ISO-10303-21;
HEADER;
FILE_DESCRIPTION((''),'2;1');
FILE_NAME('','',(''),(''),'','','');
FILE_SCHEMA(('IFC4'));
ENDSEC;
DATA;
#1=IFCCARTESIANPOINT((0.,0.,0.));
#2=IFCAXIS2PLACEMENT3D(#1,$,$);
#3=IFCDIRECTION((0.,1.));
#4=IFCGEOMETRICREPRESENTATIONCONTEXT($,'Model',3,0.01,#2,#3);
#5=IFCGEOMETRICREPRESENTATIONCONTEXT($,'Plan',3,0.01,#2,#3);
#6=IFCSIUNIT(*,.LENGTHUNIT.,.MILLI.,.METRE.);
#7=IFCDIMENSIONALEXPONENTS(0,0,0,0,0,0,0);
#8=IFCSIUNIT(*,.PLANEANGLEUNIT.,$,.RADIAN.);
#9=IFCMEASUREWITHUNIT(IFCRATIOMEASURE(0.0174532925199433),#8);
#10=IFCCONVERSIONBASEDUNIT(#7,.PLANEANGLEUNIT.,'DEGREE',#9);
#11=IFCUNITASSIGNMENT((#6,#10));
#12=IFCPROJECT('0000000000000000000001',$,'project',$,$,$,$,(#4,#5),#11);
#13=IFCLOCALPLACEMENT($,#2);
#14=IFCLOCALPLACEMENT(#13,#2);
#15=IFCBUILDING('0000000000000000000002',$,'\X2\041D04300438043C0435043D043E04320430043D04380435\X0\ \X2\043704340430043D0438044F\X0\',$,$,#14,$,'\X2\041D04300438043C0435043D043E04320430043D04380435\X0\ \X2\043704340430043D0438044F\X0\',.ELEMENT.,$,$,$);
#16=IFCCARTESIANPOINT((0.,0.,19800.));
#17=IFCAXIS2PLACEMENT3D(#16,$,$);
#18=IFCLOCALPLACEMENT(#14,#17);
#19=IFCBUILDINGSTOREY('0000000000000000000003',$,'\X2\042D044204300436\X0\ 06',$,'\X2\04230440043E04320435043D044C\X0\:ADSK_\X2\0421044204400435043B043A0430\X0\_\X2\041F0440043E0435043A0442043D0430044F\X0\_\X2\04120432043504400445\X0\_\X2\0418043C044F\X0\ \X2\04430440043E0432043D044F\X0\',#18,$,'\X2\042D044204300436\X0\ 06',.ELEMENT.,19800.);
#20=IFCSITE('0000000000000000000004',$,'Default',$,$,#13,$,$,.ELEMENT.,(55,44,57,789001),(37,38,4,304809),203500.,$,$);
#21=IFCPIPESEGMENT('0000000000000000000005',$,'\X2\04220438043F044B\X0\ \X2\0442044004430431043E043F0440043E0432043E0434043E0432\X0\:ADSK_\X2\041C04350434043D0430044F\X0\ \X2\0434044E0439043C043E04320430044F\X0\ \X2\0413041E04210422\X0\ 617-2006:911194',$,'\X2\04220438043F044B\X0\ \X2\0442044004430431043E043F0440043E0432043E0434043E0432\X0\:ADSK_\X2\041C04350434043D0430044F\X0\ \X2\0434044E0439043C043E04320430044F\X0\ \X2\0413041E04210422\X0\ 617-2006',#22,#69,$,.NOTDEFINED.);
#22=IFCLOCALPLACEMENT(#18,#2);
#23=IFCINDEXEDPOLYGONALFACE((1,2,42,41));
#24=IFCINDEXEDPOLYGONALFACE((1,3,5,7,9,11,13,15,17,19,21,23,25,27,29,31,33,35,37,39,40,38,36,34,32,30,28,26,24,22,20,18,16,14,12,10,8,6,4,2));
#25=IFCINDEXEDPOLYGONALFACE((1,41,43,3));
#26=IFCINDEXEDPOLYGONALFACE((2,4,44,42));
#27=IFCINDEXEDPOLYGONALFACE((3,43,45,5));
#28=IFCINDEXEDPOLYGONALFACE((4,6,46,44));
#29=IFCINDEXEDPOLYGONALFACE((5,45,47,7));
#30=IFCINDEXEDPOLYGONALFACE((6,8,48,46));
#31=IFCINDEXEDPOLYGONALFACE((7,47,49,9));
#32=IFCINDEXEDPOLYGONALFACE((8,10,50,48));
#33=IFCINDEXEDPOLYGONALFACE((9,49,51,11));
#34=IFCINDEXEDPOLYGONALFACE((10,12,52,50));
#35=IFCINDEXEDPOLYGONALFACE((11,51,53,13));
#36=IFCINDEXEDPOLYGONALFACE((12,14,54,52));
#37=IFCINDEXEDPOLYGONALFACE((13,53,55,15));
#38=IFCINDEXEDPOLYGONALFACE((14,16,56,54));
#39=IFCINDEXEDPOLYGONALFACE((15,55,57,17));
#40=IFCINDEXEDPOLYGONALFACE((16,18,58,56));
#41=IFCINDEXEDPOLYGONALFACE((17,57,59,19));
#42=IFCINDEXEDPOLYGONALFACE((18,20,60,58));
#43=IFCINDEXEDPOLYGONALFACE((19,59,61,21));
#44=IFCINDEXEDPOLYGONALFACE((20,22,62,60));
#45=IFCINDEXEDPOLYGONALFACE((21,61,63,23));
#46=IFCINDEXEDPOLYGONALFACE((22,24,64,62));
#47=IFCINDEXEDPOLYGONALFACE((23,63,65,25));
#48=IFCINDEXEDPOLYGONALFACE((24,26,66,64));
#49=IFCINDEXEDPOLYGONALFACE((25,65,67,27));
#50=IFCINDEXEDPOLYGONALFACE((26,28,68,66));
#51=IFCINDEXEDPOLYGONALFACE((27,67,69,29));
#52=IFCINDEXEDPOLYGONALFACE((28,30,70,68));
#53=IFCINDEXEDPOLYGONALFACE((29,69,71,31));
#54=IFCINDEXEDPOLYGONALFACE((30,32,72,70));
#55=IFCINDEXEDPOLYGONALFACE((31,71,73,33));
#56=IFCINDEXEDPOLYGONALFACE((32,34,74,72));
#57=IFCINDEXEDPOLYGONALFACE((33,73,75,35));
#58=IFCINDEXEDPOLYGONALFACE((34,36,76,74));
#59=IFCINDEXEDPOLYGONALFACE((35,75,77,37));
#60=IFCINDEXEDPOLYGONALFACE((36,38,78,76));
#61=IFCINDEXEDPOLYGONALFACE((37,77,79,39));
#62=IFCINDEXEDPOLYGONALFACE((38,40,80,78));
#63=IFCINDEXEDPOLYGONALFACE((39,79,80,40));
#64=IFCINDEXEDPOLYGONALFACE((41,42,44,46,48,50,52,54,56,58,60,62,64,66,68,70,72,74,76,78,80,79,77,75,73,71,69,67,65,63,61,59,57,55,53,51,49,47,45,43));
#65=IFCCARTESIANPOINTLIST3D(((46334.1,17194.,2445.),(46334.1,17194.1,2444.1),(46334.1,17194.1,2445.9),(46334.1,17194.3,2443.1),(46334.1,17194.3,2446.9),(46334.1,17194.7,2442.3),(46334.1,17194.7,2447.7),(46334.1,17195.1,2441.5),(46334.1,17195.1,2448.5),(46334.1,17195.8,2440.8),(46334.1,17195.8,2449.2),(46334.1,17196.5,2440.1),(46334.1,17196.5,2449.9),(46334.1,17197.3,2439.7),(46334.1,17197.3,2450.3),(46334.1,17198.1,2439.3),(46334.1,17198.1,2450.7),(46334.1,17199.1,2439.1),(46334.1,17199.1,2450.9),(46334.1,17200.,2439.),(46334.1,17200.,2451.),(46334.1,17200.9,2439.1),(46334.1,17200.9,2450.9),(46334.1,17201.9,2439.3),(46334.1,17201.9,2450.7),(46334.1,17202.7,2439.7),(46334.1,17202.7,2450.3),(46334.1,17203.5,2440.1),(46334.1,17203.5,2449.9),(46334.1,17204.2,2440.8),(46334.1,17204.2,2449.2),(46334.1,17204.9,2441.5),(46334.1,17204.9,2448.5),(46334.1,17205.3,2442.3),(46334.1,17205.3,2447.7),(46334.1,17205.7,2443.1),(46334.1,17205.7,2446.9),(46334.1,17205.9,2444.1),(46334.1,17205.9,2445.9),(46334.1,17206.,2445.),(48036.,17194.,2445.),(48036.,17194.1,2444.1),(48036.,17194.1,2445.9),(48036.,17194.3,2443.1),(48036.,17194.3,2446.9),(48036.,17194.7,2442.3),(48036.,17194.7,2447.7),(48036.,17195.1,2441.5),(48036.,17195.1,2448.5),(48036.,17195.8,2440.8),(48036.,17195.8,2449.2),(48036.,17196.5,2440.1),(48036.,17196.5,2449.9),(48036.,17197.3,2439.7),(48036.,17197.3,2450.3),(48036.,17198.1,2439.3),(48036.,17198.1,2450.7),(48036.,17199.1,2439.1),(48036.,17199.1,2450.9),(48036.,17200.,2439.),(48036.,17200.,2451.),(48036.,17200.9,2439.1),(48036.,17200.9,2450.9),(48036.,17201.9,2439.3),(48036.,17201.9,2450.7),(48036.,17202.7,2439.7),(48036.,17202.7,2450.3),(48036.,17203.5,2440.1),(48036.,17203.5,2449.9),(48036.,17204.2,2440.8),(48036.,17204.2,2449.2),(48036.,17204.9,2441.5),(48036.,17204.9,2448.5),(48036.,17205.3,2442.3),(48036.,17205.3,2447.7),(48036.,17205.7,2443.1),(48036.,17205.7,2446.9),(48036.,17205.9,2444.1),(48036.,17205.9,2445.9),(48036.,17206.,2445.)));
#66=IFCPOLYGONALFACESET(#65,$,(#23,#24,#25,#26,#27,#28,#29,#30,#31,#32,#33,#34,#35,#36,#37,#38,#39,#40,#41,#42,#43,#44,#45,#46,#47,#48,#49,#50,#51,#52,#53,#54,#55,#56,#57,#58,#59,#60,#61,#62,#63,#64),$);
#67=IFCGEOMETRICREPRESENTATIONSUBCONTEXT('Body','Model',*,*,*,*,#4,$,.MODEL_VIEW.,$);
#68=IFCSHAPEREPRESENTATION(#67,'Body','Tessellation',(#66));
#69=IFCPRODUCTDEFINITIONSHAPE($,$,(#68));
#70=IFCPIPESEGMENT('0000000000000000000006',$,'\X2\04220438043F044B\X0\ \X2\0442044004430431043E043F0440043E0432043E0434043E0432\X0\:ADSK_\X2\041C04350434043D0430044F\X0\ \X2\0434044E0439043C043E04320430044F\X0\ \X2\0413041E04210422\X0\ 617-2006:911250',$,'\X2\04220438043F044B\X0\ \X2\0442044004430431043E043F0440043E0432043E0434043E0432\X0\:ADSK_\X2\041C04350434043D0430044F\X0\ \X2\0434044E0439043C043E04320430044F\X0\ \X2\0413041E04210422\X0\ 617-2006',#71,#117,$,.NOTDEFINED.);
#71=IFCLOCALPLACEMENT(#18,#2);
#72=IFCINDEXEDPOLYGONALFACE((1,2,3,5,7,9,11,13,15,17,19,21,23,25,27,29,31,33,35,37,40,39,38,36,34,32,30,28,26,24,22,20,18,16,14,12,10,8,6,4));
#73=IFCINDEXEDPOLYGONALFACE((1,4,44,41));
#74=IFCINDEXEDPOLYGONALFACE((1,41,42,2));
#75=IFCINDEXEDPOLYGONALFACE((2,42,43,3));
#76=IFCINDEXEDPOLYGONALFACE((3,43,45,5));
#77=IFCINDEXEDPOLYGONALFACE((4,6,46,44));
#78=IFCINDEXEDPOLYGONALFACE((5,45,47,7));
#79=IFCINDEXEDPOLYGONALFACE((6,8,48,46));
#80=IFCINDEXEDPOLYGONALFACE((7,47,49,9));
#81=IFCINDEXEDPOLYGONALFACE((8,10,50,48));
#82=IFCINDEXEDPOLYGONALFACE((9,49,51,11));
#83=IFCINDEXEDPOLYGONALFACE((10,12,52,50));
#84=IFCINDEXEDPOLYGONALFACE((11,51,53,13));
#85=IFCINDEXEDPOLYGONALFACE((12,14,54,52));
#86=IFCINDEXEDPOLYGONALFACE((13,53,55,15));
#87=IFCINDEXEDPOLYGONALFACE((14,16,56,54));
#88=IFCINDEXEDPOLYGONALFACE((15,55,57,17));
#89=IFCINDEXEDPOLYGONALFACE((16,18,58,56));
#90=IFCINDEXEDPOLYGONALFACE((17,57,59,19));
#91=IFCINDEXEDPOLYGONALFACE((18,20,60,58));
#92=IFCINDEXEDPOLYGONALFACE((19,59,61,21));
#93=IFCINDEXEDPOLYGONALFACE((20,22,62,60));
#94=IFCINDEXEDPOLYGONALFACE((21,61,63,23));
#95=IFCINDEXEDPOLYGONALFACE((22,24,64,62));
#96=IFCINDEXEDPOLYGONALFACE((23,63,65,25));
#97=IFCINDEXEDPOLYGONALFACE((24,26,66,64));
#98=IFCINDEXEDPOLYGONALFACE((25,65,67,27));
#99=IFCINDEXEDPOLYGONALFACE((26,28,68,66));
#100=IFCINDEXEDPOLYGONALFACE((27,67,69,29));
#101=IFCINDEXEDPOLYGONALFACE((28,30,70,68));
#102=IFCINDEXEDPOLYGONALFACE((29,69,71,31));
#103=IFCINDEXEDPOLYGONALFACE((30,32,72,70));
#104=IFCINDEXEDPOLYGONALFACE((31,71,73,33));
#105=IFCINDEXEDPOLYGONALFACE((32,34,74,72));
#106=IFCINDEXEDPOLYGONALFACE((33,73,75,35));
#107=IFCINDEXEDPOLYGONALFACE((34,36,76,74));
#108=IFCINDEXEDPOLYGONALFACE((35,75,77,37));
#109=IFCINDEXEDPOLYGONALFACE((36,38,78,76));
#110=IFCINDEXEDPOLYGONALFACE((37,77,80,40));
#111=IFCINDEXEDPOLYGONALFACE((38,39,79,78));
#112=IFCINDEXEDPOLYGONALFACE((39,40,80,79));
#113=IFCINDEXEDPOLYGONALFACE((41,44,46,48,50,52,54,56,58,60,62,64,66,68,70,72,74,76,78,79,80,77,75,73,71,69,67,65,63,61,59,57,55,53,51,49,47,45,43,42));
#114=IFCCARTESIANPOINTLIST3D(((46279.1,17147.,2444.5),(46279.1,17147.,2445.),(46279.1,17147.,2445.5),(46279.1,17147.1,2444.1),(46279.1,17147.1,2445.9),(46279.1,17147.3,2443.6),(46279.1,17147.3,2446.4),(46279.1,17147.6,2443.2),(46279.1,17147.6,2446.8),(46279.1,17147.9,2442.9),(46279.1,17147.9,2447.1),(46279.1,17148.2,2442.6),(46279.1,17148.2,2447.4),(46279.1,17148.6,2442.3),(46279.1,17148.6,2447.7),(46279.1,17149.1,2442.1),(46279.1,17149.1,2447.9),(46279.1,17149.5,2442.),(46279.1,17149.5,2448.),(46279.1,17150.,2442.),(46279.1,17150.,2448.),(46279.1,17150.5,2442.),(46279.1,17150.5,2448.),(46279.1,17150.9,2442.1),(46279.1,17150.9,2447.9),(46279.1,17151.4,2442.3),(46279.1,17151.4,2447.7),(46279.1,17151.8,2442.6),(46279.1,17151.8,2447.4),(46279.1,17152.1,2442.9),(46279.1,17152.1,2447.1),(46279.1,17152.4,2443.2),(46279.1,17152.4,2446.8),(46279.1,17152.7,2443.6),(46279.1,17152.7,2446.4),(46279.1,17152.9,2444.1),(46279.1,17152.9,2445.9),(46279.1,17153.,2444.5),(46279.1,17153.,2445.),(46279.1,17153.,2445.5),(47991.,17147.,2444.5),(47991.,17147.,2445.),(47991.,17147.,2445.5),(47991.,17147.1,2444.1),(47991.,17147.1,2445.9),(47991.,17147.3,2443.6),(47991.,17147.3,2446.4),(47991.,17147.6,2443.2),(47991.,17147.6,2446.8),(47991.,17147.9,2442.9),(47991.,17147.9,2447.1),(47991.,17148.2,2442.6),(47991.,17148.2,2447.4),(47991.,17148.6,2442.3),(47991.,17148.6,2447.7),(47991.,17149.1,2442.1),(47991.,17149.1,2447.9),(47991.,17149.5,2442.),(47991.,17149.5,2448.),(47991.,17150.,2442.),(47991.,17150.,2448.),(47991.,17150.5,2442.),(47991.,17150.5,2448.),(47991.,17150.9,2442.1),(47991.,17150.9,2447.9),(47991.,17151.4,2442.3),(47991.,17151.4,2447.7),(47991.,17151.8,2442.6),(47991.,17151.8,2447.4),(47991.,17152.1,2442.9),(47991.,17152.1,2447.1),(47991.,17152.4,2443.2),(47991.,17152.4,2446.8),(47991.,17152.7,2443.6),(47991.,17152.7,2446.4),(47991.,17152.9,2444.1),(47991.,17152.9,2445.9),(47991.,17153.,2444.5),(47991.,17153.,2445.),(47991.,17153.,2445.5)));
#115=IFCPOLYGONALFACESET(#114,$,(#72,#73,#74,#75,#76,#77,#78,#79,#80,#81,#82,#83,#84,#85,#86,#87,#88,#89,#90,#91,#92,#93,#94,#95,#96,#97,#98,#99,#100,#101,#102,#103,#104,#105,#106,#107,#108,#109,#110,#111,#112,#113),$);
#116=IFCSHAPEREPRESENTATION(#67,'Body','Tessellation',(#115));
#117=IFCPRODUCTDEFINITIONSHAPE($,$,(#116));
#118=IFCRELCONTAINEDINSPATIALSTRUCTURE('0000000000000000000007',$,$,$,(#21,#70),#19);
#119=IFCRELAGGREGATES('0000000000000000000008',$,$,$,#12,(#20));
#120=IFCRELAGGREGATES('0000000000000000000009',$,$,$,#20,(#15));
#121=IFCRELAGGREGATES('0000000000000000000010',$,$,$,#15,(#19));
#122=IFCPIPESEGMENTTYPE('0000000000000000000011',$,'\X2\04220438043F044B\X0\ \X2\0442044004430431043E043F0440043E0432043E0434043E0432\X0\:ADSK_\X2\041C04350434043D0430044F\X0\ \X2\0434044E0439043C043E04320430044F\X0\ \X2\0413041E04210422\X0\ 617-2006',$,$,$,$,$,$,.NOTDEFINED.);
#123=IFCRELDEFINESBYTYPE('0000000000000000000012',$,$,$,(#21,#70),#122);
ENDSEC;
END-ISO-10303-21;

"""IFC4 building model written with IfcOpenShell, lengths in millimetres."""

from ifc_helpers import new_model, entity, si_unit, converted_unit, direction, frame, origin, place, context, subcontext, project, spatial, indexed_curve, outline, extrude, type_object, element, save


model = new_model("IFC4")

# Units and contexts
model_context = context("Model", 3, precision=0.01, world=origin(), true_north=direction((0.0, 1.0)))
plan_context = context("Plan", 3, precision=0.01, world=origin(), true_north=direction((0.0, 1.0)))
body_context = subcontext(model_context, "Body", "Model", "MODEL_VIEW")
ifc_project = project(units=[si_unit("LENGTHUNIT", "METRE", prefix="MILLI"), converted_unit("PLANEANGLEUNIT", "DEGREE", entity("IfcRatioMeasure", 0.0174532925199433), si_unit("PLANEANGLEUNIT", "RADIAN"), dimensions=[0, 0, 0, 0, 0, 0, 0])], contexts=[model_context, plan_context])

# Site, building, storey
site_placement = place(None, origin())
site = spatial("IfcSite", under=ifc_project, at=site_placement, Name="Default", CompositionType="ELEMENT", RefLatitude=(55, 44, 57, 789001), RefLongitude=(37, 38, 4, 304809), RefElevation=203500.0)
building_placement = place(site_placement, origin())
building = spatial("IfcBuilding", under=site, at=building_placement, Name="Наименование здания", LongName="Наименование здания", CompositionType="ELEMENT")
storey_placement = place(building_placement, frame((0.0, 0.0, 19800.0)))
storey = spatial("IfcBuildingStorey", under=building, at=storey_placement, Name="Этаж 06", ObjectType="Уровень:ADSK_Стрелка_Проектная_Вверх_Имя уровня", LongName="Этаж 06", CompositionType="ELEMENT", Elevation=19800.0)

# Pipe segments
pipe_segment_type = type_object("IfcPipeSegmentType", Name="Типы трубопроводов:ADSK_Медная дюймовая ГОСТ 617-2006", PredefinedType="NOTDEFINED")
placement = place(storey_placement, origin())
element("IfcPipeSegment", 1, at=placement, inside=storey, type_object=pipe_segment_type, Name="Типы трубопроводов:ADSK_Медная дюймовая ГОСТ 617-2006:911194", ObjectType="Типы трубопроводов:ADSK_Медная дюймовая ГОСТ 617-2006", PredefinedType="NOTDEFINED", context=body_context, shape_type="SweptSolid", body=[
    extrude(outline(indexed_curve([(6.0, 0.0), (5.9, 0.9), (5.7, 1.9), (5.3, 2.7), (4.9, 3.5), (4.2, 4.2), (3.5, 4.9), (2.7, 5.3), (1.9, 5.7), (0.9, 5.9), (0.0, 6.0), (-0.9, 5.9), (-1.9, 5.7), (-2.7, 5.3), (-3.5, 4.9), (-4.2, 4.2), (-4.9, 3.5), (-5.3, 2.7), (-5.7, 1.9), (-5.9, 0.9), (-6.0, 0.0), (-5.9, -0.9), (-5.7, -1.9), (-5.3, -2.7), (-4.9, -3.5), (-4.2, -4.2), (-3.5, -4.9), (-2.7, -5.3), (-1.9, -5.7), (-0.9, -5.9), (0.0, -6.0), (0.9, -5.9), (1.9, -5.7), (2.7, -5.3), (3.5, -4.9), (4.2, -4.2), (4.9, -3.5), (5.3, -2.7), (5.7, -1.9), (5.9, -0.9), (6.0, 0.0)], self_intersect=False)), frame((46334.1, 17200.0, 2445.0), z_axis=(1.0, 0.0, 0.0), x_axis=(0.0, 1.0, 0.0)), (0.0, 0.0, 1.0), 1701.9),
])
element("IfcPipeSegment", 2, at=placement, inside=storey, type_object=pipe_segment_type, Name="Типы трубопроводов:ADSK_Медная дюймовая ГОСТ 617-2006:911250", ObjectType="Типы трубопроводов:ADSK_Медная дюймовая ГОСТ 617-2006", PredefinedType="NOTDEFINED", context=body_context, shape_type="SweptSolid", body=[
    extrude(outline(indexed_curve([(3.0, 0.0), (3.0, 0.5), (2.9, 0.9), (2.7, 1.4), (2.4, 1.8), (2.1, 2.1), (1.8, 2.4), (1.4, 2.7), (0.9, 2.9), (0.5, 3.0), (0.0, 3.0), (-0.5, 3.0), (-0.9, 2.9), (-1.4, 2.7), (-1.8, 2.4), (-2.1, 2.1), (-2.4, 1.8), (-2.7, 1.4), (-2.9, 0.9), (-3.0, 0.5), (-3.0, 0.0), (-3.0, -0.5), (-2.9, -0.9), (-2.7, -1.4), (-2.4, -1.8), (-2.1, -2.1), (-1.8, -2.4), (-1.4, -2.7), (-0.9, -2.9), (-0.5, -3.0), (0.0, -3.0), (0.5, -3.0), (0.9, -2.9), (1.4, -2.7), (1.8, -2.4), (2.1, -2.1), (2.4, -1.8), (2.7, -1.4), (2.9, -0.9), (3.0, -0.5), (3.0, 0.0)], self_intersect=False)), frame((46279.1, 17150.0, 2445.0), z_axis=(1.0, 0.0, 0.0), x_axis=(0.0, 1.0, 0.0)), (0.0, 0.0, 1.0), 1711.9),
])

save(model, "model.ifc")
